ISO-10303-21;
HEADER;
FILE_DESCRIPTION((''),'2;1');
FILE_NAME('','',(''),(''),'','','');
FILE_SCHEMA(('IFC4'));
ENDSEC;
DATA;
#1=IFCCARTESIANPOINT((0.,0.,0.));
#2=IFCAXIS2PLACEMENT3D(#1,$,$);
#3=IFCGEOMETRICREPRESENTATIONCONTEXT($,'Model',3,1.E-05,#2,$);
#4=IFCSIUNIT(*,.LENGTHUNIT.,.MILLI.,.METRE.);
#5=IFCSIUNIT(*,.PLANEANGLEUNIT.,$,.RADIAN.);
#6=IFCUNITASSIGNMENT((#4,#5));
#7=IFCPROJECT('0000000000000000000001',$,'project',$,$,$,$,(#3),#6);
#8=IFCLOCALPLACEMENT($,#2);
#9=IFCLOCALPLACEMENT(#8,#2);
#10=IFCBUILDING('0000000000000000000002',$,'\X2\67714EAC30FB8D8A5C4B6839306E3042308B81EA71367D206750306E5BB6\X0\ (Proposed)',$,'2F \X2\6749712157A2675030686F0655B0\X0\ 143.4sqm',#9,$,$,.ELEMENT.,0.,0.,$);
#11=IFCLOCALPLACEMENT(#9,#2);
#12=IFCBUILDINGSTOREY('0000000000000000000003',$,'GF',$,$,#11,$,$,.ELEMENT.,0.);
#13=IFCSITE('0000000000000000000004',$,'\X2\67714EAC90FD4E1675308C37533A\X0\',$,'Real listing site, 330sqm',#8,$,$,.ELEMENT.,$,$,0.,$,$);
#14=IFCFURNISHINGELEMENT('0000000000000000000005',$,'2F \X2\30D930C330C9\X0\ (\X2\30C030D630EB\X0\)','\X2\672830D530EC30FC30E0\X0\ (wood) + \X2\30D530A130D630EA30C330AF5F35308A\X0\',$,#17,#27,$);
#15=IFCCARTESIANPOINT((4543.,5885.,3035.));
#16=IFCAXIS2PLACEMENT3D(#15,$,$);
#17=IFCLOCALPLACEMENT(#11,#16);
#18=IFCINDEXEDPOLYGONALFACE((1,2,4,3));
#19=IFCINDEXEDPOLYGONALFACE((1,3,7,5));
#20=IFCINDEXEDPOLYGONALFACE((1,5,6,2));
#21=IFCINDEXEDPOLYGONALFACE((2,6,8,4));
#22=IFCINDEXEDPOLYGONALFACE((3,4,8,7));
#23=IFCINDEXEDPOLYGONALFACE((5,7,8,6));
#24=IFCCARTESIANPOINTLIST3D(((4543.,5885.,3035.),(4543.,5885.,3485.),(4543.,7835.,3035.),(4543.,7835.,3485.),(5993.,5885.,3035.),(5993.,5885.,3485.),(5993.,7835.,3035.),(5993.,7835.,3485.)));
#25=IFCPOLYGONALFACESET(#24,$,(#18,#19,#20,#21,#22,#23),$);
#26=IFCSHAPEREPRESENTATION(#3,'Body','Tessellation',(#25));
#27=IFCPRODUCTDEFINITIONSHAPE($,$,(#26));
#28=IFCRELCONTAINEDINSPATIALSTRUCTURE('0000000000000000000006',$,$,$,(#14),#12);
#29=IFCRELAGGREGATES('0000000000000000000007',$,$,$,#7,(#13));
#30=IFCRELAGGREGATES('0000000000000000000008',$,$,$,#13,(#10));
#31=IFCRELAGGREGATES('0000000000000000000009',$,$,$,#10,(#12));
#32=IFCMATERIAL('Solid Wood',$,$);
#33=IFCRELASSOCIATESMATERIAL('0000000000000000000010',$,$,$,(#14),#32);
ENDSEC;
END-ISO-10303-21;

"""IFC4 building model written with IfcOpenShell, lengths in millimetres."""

from ifc_helpers import new_model, si_unit, frame, frame_2d, origin, place, context, project, spatial, rectangle, extrude, material, element, save


model = new_model("IFC4")

# Units and contexts
model_context = context("Model", 3, precision=1e-05, world=origin())
ifc_project = project(units=[si_unit("LENGTHUNIT", "METRE", prefix="MILLI"), si_unit("PLANEANGLEUNIT", "RADIAN")], contexts=[model_context])

# Site, building, storey
site_placement = place(None, origin())
site = spatial("IfcSite", under=ifc_project, at=site_placement, Name="東京都世田谷区", ObjectType="Real listing site, 330sqm", CompositionType="ELEMENT", RefElevation=0.0)
building_placement = place(site_placement, origin())
building = spatial("IfcBuilding", under=site, at=building_placement, Name="東京・越屋根のある自然素材の家 (Proposed)", ObjectType="2F 杉無垢材と漆喰 143.4sqm", CompositionType="ELEMENT", ElevationOfRefHeight=0.0, ElevationOfTerrain=0.0)
storey_placement = place(building_placement, origin())
storey = spatial("IfcBuildingStorey", under=building, at=storey_placement, Name="GF", CompositionType="ELEMENT", Elevation=0.0)

# Shared definitions
ifc_material_1 = material(Name="Solid Wood")

# Furnishing element
furnishing_1_placement = place(storey_placement, frame((4543.0, 5885.0, 3035.0)))
element("IfcFurnishingElement", 1, at=furnishing_1_placement, inside=storey, material=ifc_material_1, Name="2F ベッド (ダブル)", Description="木フレーム (wood) + ファブリック張り", context=model_context, shape_type="SweptSolid", body=[
    extrude(rectangle(XDim=1450.0, YDim=1950.0, at=frame_2d((725.0, 975.0))), frame((4543.0, 5885.0, 3035.0)), (0.0, 0.0, 1.0), 450.0),
])

save(model, "model.ifc")
